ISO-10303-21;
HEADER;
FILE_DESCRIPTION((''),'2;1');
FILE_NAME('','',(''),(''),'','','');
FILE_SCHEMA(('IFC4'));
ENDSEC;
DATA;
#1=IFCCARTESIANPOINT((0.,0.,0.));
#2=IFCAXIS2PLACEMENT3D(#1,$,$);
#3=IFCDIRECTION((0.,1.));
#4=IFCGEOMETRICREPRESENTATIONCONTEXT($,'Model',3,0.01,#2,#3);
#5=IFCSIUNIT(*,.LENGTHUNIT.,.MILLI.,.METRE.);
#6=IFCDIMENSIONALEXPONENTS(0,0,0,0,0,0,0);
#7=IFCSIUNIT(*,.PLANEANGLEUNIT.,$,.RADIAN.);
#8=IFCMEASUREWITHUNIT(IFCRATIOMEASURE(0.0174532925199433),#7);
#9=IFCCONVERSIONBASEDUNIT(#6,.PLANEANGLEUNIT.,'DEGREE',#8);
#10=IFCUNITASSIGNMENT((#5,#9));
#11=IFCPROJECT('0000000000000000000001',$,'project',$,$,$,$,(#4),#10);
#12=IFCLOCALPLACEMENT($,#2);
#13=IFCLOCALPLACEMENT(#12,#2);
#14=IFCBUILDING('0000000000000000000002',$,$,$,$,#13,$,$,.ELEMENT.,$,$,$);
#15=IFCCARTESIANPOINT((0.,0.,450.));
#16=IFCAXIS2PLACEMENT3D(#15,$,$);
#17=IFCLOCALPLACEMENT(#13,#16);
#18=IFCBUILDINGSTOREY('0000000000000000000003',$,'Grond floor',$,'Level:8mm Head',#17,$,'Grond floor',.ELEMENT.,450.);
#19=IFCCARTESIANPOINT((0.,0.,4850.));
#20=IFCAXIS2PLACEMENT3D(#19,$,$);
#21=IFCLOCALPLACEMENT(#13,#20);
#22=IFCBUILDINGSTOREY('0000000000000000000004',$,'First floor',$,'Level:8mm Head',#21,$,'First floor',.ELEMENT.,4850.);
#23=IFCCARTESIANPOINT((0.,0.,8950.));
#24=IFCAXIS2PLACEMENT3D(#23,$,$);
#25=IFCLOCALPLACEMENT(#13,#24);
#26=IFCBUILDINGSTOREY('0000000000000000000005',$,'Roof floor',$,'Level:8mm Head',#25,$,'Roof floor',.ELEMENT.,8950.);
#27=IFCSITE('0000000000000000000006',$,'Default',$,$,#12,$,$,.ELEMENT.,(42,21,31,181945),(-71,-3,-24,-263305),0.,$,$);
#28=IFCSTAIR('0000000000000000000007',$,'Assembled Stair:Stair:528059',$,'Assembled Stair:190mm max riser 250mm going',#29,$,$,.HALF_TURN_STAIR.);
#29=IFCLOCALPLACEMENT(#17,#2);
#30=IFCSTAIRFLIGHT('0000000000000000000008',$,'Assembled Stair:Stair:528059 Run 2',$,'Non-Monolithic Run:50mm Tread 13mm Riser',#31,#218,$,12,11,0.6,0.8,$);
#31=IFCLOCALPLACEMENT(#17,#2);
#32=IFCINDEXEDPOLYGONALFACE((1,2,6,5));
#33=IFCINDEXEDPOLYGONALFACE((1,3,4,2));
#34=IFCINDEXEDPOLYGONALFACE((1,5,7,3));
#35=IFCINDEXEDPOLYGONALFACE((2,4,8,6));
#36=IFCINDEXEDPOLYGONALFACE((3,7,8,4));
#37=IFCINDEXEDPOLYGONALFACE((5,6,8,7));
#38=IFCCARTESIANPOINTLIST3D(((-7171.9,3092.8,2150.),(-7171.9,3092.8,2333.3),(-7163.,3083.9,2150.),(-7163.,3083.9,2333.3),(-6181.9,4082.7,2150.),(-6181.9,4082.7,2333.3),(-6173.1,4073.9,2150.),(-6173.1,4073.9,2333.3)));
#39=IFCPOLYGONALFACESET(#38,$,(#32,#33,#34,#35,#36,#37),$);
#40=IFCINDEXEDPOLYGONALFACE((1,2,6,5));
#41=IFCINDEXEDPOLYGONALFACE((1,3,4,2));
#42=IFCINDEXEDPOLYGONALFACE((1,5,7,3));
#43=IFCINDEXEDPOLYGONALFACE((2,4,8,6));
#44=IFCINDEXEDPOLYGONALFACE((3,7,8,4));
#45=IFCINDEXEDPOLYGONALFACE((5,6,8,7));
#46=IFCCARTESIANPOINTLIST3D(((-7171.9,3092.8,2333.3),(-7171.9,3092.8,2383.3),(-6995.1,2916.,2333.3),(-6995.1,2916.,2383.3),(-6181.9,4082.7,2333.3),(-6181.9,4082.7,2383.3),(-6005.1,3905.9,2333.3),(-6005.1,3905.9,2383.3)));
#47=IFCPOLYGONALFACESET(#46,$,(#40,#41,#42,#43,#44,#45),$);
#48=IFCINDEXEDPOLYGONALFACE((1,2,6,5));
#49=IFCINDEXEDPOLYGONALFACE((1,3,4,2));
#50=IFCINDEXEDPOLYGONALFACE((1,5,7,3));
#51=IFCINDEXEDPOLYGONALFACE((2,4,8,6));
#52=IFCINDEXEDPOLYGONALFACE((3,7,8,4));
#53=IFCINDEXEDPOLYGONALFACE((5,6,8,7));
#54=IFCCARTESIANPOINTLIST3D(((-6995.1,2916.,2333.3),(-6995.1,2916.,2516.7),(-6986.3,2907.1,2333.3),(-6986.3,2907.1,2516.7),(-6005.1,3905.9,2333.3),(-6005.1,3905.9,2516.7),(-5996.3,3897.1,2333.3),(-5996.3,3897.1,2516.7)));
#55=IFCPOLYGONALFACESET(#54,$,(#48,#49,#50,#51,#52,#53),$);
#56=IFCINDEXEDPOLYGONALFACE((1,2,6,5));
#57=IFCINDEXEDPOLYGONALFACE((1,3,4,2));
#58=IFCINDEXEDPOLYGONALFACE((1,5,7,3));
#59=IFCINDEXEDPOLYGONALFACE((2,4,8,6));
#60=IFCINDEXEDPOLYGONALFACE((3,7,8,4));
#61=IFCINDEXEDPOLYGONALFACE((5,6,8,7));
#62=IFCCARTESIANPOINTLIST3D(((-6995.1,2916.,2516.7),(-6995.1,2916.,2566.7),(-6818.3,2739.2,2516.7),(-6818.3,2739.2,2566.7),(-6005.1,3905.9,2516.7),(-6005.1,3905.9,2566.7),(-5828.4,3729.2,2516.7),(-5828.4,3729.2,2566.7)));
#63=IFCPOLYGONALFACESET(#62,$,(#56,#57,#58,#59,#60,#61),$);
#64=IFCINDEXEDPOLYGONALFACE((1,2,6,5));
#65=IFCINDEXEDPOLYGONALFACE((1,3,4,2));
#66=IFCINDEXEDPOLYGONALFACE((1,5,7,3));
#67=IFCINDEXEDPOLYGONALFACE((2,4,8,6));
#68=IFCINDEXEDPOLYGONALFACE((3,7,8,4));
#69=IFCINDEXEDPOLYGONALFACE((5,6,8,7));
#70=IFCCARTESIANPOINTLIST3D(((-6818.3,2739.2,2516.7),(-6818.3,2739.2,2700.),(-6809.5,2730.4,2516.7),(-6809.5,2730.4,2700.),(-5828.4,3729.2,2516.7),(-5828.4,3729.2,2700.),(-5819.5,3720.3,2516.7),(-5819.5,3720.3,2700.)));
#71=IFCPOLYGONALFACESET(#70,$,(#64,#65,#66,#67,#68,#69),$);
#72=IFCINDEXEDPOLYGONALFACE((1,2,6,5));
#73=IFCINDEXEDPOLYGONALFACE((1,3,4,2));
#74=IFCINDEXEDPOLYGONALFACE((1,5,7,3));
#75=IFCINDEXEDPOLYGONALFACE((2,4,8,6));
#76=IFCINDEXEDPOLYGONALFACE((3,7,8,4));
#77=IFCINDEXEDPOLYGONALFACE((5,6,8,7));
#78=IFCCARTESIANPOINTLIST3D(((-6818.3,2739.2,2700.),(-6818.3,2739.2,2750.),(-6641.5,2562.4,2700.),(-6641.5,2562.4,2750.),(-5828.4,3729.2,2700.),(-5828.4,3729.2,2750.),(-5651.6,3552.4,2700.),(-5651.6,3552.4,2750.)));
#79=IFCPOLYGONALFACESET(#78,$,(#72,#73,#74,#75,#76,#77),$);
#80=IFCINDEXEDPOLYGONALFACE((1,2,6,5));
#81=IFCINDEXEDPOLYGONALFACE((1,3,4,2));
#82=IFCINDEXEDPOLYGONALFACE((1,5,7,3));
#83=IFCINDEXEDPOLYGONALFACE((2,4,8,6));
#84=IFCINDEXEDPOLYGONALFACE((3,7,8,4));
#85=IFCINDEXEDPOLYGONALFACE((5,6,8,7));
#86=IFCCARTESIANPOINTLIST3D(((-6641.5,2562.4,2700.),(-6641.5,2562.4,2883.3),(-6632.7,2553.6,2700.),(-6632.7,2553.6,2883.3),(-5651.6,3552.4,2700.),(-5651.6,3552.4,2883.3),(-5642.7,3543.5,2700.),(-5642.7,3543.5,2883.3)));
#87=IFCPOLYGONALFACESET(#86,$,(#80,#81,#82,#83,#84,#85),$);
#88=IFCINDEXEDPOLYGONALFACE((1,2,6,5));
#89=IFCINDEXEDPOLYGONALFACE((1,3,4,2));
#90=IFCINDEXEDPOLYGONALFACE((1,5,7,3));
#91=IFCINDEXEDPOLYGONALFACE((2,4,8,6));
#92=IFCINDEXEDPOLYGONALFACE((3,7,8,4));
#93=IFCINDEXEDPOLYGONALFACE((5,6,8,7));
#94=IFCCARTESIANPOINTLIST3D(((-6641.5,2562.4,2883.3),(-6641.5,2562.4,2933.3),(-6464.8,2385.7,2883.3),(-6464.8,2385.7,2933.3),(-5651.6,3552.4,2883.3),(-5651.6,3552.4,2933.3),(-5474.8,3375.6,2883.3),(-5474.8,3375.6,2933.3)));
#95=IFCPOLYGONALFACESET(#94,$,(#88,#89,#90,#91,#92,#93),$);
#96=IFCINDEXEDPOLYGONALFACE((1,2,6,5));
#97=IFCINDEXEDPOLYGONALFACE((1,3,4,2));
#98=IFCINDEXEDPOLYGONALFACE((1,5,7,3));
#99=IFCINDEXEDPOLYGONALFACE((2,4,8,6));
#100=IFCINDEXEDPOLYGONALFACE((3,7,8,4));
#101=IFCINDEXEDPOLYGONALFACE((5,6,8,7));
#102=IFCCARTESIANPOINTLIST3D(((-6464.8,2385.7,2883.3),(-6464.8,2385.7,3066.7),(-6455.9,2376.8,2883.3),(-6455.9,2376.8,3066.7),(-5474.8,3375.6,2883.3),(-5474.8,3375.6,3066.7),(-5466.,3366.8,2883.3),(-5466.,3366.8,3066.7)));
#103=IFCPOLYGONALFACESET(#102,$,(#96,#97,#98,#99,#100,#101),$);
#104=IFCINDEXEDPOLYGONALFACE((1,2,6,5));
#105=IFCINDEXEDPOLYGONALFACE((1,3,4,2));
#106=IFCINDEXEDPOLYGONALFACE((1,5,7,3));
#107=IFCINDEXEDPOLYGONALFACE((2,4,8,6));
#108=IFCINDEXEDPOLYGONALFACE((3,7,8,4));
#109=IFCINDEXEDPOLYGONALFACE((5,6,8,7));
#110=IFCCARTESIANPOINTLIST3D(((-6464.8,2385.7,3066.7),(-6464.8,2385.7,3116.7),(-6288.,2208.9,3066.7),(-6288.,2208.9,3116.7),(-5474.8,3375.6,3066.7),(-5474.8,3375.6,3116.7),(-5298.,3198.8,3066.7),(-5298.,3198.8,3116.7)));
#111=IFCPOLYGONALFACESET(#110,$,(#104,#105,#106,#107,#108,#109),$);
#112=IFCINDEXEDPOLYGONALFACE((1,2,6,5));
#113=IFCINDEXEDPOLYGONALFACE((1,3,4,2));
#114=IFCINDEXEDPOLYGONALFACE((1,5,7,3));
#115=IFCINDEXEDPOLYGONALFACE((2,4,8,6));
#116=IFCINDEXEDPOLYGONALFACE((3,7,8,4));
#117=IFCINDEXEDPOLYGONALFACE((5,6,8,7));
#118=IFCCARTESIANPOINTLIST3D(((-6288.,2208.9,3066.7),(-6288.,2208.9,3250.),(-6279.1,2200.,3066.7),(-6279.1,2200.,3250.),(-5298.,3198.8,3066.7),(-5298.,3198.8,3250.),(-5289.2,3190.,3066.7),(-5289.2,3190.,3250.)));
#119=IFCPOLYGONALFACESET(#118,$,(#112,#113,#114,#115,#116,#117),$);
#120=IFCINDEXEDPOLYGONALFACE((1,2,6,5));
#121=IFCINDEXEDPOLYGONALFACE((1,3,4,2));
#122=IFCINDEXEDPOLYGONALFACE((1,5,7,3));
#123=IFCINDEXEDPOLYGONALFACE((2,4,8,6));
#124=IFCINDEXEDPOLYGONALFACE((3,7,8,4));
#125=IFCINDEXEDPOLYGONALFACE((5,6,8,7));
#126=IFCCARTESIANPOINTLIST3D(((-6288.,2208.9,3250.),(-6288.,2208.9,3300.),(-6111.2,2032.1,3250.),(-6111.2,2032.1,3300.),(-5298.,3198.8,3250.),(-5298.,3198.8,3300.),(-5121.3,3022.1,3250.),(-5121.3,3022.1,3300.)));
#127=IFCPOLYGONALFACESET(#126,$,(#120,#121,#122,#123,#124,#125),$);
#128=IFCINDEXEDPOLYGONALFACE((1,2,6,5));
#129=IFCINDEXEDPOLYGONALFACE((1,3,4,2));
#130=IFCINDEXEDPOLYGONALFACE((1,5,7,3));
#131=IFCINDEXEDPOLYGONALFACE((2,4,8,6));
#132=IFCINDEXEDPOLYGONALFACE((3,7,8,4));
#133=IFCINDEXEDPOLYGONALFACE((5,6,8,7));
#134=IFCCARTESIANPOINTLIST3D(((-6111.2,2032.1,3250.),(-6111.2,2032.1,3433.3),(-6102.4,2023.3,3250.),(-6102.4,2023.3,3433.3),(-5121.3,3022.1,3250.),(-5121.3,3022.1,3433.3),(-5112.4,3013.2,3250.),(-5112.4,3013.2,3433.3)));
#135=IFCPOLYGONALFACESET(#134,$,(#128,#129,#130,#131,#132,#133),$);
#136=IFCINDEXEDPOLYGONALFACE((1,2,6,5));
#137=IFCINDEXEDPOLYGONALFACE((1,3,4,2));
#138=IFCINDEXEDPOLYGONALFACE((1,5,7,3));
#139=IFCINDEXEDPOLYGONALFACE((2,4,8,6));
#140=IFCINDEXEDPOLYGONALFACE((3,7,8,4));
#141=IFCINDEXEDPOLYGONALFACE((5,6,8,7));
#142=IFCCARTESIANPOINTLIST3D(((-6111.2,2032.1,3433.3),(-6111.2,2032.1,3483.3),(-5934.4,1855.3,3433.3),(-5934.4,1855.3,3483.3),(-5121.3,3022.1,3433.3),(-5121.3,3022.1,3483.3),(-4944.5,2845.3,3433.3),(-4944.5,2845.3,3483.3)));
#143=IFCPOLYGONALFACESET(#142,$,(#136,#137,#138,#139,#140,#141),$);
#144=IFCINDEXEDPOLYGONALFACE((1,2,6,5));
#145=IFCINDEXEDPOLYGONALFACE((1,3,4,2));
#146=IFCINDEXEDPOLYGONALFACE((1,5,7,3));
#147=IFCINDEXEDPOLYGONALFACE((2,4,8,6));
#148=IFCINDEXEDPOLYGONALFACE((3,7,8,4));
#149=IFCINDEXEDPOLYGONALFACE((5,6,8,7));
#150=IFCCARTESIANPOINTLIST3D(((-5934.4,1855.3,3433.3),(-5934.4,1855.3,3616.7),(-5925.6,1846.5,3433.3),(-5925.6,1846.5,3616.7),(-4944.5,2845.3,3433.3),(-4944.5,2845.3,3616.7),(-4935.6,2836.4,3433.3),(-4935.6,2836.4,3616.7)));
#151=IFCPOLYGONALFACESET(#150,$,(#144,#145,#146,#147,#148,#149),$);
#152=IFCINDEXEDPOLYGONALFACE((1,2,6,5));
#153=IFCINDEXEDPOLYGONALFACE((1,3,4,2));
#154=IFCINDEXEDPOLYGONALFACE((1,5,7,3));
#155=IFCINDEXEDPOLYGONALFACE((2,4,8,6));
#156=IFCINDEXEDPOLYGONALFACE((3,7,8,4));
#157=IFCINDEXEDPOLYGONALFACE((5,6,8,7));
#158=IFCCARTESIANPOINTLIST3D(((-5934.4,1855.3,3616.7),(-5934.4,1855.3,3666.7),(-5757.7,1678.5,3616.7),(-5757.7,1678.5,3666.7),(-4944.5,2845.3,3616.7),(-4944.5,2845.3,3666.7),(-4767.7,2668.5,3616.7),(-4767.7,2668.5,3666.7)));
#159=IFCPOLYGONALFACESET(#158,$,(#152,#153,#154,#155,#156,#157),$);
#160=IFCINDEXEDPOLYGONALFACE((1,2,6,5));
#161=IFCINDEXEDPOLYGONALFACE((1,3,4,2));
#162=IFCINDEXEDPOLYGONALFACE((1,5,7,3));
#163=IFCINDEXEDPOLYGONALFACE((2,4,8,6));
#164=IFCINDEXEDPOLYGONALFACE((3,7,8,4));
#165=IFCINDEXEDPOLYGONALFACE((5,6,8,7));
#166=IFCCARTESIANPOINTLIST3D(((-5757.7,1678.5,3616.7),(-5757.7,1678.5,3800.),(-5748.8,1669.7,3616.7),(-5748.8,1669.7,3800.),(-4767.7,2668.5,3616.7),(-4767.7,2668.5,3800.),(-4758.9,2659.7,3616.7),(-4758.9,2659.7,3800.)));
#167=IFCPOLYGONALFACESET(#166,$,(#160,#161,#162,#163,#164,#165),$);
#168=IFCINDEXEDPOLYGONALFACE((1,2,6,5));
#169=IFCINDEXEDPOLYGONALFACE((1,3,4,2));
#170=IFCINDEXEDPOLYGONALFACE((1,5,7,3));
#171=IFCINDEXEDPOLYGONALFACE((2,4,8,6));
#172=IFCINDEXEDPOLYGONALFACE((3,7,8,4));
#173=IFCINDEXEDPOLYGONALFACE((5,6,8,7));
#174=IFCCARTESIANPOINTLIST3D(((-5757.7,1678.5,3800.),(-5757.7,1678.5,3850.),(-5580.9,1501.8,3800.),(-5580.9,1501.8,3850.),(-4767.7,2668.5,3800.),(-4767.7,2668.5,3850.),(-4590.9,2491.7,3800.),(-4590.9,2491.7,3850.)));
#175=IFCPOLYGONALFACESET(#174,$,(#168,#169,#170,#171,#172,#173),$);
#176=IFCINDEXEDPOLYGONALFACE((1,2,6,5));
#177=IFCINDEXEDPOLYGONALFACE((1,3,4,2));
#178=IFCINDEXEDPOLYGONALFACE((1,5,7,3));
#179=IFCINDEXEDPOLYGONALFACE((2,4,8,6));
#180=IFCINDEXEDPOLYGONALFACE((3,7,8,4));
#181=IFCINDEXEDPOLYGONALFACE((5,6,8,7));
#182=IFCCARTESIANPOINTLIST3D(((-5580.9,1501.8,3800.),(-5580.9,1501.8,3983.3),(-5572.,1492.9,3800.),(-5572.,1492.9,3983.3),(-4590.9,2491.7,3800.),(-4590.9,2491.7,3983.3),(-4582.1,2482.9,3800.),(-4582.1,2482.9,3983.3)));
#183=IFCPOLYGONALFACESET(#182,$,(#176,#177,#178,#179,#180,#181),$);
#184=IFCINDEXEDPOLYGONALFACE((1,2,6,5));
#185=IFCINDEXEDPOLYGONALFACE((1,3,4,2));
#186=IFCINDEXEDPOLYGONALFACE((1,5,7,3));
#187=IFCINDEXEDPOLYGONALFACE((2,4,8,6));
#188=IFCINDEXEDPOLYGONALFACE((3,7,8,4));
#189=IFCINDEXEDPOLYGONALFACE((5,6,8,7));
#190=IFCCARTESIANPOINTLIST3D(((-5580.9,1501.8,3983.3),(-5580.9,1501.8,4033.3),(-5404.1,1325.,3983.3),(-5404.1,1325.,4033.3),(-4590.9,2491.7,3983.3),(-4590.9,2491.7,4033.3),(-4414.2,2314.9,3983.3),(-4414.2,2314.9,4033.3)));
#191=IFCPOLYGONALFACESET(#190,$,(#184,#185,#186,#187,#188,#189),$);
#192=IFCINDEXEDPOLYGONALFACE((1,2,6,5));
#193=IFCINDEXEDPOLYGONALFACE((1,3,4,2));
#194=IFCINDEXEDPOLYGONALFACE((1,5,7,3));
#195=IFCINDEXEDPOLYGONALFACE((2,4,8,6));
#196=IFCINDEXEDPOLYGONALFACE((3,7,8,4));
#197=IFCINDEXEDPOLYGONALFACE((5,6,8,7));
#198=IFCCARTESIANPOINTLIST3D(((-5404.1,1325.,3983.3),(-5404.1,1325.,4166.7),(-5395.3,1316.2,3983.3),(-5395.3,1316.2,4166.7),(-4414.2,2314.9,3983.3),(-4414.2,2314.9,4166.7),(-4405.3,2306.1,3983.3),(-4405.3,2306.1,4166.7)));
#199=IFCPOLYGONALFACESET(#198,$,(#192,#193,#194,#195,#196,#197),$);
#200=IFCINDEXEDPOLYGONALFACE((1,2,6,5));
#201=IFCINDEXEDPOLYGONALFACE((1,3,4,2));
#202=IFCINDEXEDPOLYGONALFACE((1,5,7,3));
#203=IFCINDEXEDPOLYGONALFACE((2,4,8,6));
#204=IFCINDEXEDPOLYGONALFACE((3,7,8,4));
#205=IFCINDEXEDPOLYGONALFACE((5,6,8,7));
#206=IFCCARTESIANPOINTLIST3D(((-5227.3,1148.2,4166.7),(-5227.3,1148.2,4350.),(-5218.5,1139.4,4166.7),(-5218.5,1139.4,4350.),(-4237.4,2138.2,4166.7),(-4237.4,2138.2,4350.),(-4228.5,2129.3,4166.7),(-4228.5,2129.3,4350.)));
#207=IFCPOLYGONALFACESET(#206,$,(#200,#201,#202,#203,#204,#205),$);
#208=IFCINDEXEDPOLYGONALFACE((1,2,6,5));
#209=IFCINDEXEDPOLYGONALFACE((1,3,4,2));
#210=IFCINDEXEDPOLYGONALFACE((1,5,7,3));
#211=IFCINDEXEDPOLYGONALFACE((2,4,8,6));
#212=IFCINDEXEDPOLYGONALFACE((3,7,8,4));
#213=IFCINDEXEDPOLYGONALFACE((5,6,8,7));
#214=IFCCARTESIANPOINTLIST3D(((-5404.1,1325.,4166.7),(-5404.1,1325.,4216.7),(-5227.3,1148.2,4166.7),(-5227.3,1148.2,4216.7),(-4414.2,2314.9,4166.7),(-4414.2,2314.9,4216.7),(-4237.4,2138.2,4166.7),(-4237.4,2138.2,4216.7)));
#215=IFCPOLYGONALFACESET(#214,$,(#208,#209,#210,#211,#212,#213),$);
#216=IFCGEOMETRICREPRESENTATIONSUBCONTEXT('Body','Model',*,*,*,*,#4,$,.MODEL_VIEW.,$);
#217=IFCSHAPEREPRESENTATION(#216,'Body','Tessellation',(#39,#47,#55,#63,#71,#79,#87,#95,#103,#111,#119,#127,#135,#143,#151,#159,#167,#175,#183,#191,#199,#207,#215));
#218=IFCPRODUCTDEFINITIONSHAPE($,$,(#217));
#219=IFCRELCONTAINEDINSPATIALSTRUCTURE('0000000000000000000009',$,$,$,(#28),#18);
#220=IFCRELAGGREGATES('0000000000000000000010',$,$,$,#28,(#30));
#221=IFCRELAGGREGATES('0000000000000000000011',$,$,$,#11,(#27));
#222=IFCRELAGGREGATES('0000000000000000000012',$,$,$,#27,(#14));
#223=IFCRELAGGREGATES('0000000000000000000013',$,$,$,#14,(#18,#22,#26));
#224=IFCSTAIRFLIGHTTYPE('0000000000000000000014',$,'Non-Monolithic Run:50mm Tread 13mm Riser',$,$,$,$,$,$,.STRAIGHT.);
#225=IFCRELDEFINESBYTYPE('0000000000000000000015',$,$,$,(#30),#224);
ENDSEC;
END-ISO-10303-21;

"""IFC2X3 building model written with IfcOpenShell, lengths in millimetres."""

from ifc_helpers import new_model, entity, si_unit, converted_unit, direction, frame, frame_2d, origin, origin_2d_with_axis, place, context, subcontext, project, spatial, rectangle, extrude, type_object, element, aggregate, save


model = new_model("IFC2X3")

# Units and contexts
model_context = context("Model", 3, precision=0.01, world=origin(), true_north=direction((0.0, 1.0)))
body_context = subcontext(model_context, "Body", "Model", "MODEL_VIEW")
ifc_project = project(units=[si_unit("LENGTHUNIT", "METRE", prefix="MILLI"), converted_unit("PLANEANGLEUNIT", "DEGREE", entity("IfcRatioMeasure", 0.0174532925199433), si_unit("PLANEANGLEUNIT", "RADIAN"), dimensions=[0, 0, 0, 0, 0, 0, 0])], contexts=[model_context])

# Site, building, storey
site_placement = place(None, origin())
site = spatial("IfcSite", under=ifc_project, at=site_placement, Name="Default", CompositionType="ELEMENT", RefLatitude=(42, 21, 31, 181945), RefLongitude=(-71, -3, -24, -263305), RefElevation=0.0)
building_placement = place(site_placement, origin())
building = spatial("IfcBuilding", under=site, at=building_placement, CompositionType="ELEMENT")
storey_1_placement = place(building_placement, frame((0.0, 0.0, 450.0)))
storey_1 = spatial("IfcBuildingStorey", under=building, at=storey_1_placement, Name="Grond floor", ObjectType="Level:8mm Head", LongName="Grond floor", CompositionType="ELEMENT", Elevation=450.0)

# Stair
stair_1_placement = place(storey_1_placement, origin())
stair_1 = element("IfcStair", 1, at=stair_1_placement, inside=storey_1, Name="Assembled Stair:Stair:528059", ObjectType="Assembled Stair:190mm max riser 250mm going", ShapeType="HALF_TURN_STAIR")

# Shared definitions
storey_2_placement = place(building_placement, frame((0.0, 0.0, 4850.0)))
storey_2 = spatial("IfcBuildingStorey", under=building, at=storey_2_placement, Name="First floor", ObjectType="Level:8mm Head", LongName="First floor", CompositionType="ELEMENT", Elevation=4850.0)

# Shared definitions
storey_3_placement = place(building_placement, frame((0.0, 0.0, 8950.0)))
storey_3 = spatial("IfcBuildingStorey", under=building, at=storey_3_placement, Name="Roof floor", ObjectType="Level:8mm Head", LongName="Roof floor", CompositionType="ELEMENT", Elevation=8950.0)

# Stair flight
stair_flight_type_1 = type_object("IfcStairFlightType", Name="Non-Monolithic Run:50mm Tread 13mm Riser", PredefinedType="STRAIGHT")
stair_flight_1_placement = place(stair_1_placement, origin())
stair_flight_1 = element("IfcStairFlight", 2, at=stair_flight_1_placement, type_object=stair_flight_type_1, Name="Assembled Stair:Stair:528059 Run 2", ObjectType="Non-Monolithic Run:50mm Tread 13mm Riser", NumberOfRiser=12, NumberOfTreads=11, RiserHeight=0.6, TreadLength=0.8, context=body_context, shape_type="SweptSolid", body=[
    extrude(rectangle(XDim=1400.0, YDim=12.5, at=origin_2d_with_axis()), frame((-6672.5, 3583.3, 2150.0), z_axis=(0.0, 0.0, 1.0), x_axis=(0.707107, 0.707107, 0.0)), (0.0, 0.0, 1.0), 183.3),
    extrude(rectangle(XDim=250.0, YDim=1400.0, at=frame_2d((0.0, 0.0), x_axis=(1.0, 0.0))), frame((-6588.5, 3499.3, 2333.3), z_axis=(0.0, 0.0, 1.0), x_axis=(-0.707107, 0.707107, 0.0)), (0.0, 0.0, 1.0), 50.0),
    extrude(rectangle(XDim=1400.0, YDim=12.5, at=frame_2d((0.0, 0.0), x_axis=(1.0, 0.0))), frame((-6495.7, 3406.5, 2333.3), z_axis=(0.0, 0.0, 1.0), x_axis=(0.707107, 0.707107, 0.0)), (0.0, 0.0, 1.0), 183.3),
    extrude(rectangle(XDim=250.0, YDim=1400.0, at=frame_2d((0.0, 0.0), x_axis=(1.0, 0.0))), frame((-6411.7, 3322.6, 2516.7), z_axis=(0.0, 0.0, 1.0), x_axis=(-0.707107, 0.707107, 0.0)), (0.0, 0.0, 1.0), 50.0),
    extrude(rectangle(XDim=1400.0, YDim=12.5, at=frame_2d((0.0, 0.0), x_axis=(1.0, 0.0))), frame((-6318.9, 3229.8, 2516.7), z_axis=(0.0, 0.0, 1.0), x_axis=(0.707107, 0.707107, 0.0)), (0.0, 0.0, 1.0), 183.3),
    extrude(rectangle(XDim=250.0, YDim=1400.0, at=frame_2d((0.0, 0.0), x_axis=(1.0, 0.0))), frame((-6235.0, 3145.8, 2700.0), z_axis=(0.0, 0.0, 1.0), x_axis=(-0.707107, 0.707107, 0.0)), (0.0, 0.0, 1.0), 50.0),
    extrude(rectangle(XDim=1400.0, YDim=12.5, at=frame_2d((0.0, 0.0), x_axis=(1.0, 0.0))), frame((-6142.1, 3053.0, 2700.0), z_axis=(0.0, 0.0, 1.0), x_axis=(0.707107, 0.707107, 0.0)), (0.0, 0.0, 1.0), 183.3),
    extrude(rectangle(XDim=250.0, YDim=1400.0, at=frame_2d((0.0, 0.0), x_axis=(1.0, 0.0))), frame((-6058.2, 2969.0, 2883.3), z_axis=(0.0, 0.0, 1.0), x_axis=(-0.707107, 0.707107, 0.0)), (0.0, 0.0, 1.0), 50.0),
    extrude(rectangle(XDim=1400.0, YDim=12.5, at=frame_2d((0.0, 0.0), x_axis=(1.0, 0.0))), frame((-5965.4, 2876.2, 2883.3), z_axis=(0.0, 0.0, 1.0), x_axis=(0.707107, 0.707107, 0.0)), (0.0, 0.0, 1.0), 183.3),
    extrude(rectangle(XDim=250.0, YDim=1400.0, at=frame_2d((0.0, 0.0), x_axis=(1.0, 0.0))), frame((-5881.4, 2792.2, 3066.7), z_axis=(0.0, 0.0, 1.0), x_axis=(-0.707107, 0.707107, 0.0)), (0.0, 0.0, 1.0), 50.0),
    extrude(rectangle(XDim=1400.0, YDim=12.5, at=frame_2d((0.0, 0.0), x_axis=(1.0, 0.0))), frame((-5788.6, 2699.4, 3066.7), z_axis=(0.0, 0.0, 1.0), x_axis=(0.707107, 0.707107, 0.0)), (0.0, 0.0, 1.0), 183.3),
    extrude(rectangle(XDim=250.0, YDim=1400.0, at=frame_2d((0.0, 0.0), x_axis=(1.0, 0.0))), frame((-5704.6, 2615.5, 3250.0), z_axis=(0.0, 0.0, 1.0), x_axis=(-0.707107, 0.707107, 0.0)), (0.0, 0.0, 1.0), 50.0),
    extrude(rectangle(XDim=1400.0, YDim=12.5, at=frame_2d((0.0, 0.0), x_axis=(1.0, 0.0))), frame((-5611.8, 2522.7, 3250.0), z_axis=(0.0, 0.0, 1.0), x_axis=(0.707107, 0.707107, 0.0)), (0.0, 0.0, 1.0), 183.3),
    extrude(rectangle(XDim=250.0, YDim=1400.0, at=frame_2d((0.0, 0.0), x_axis=(1.0, 0.0))), frame((-5527.8, 2438.7, 3433.3), z_axis=(0.0, 0.0, 1.0), x_axis=(-0.707107, 0.707107, 0.0)), (0.0, 0.0, 1.0), 50.0),
    extrude(rectangle(XDim=1400.0, YDim=12.5, at=origin_2d_with_axis()), frame((-5435.0, 2345.9, 3433.3), z_axis=(0.0, 0.0, 1.0), x_axis=(0.707107, 0.707107, 0.0)), (0.0, 0.0, 1.0), 183.3),
    extrude(rectangle(XDim=250.0, YDim=1400.0, at=frame_2d((0.0, 0.0), x_axis=(1.0, 0.0))), frame((-5351.1, 2261.9, 3616.7), z_axis=(0.0, 0.0, 1.0), x_axis=(-0.707107, 0.707107, 0.0)), (0.0, 0.0, 1.0), 50.0),
    extrude(rectangle(XDim=1400.0, YDim=12.5, at=frame_2d((0.0, 0.0), x_axis=(1.0, 0.0))), frame((-5258.3, 2169.1, 3616.7), z_axis=(0.0, 0.0, 1.0), x_axis=(0.707107, 0.707107, 0.0)), (0.0, 0.0, 1.0), 183.3),
    extrude(rectangle(XDim=250.0, YDim=1400.0, at=frame_2d((0.0, 0.0), x_axis=(1.0, 0.0))), frame((-5174.3, 2085.1, 3800.0), z_axis=(0.0, 0.0, 1.0), x_axis=(-0.707107, 0.707107, 0.0)), (0.0, 0.0, 1.0), 50.0),
    extrude(rectangle(XDim=1400.0, YDim=12.5, at=frame_2d((0.0, 0.0), x_axis=(1.0, 0.0))), frame((-5081.5, 1992.3, 3800.0), z_axis=(0.0, 0.0, 1.0), x_axis=(0.707107, 0.707107, 0.0)), (0.0, 0.0, 1.0), 183.3),
    extrude(rectangle(XDim=250.0, YDim=1400.0, at=frame_2d((0.0, 0.0), x_axis=(1.0, 0.0))), frame((-4997.5, 1908.4, 3983.3), z_axis=(0.0, 0.0, 1.0), x_axis=(-0.707107, 0.707107, 0.0)), (0.0, 0.0, 1.0), 50.0),
    extrude(rectangle(XDim=1400.0, YDim=12.5, at=frame_2d((0.0, 0.0), x_axis=(1.0, 0.0))), frame((-4904.7, 1815.5, 3983.3), z_axis=(0.0, 0.0, 1.0), x_axis=(0.707107, 0.707107, 0.0)), (0.0, 0.0, 1.0), 183.3),
    extrude(rectangle(XDim=1400.0, YDim=12.5, at=frame_2d((0.0, 0.0), x_axis=(1.0, 0.0))), frame((-4727.9, 1638.8, 4166.7), z_axis=(0.0, 0.0, 1.0), x_axis=(0.707107, 0.707107, 0.0)), (0.0, 0.0, 1.0), 183.3),
    extrude(rectangle(XDim=250.0, YDim=1400.0, at=frame_2d((0.0, 0.0), x_axis=(1.0, 0.0))), frame((-4820.7, 1731.6, 4166.7), z_axis=(0.0, 0.0, 1.0), x_axis=(-0.707107, 0.707107, 0.0)), (0.0, 0.0, 1.0), 50.0),
])
aggregate(stair_1, [stair_flight_1])

save(model, "model.ifc")
